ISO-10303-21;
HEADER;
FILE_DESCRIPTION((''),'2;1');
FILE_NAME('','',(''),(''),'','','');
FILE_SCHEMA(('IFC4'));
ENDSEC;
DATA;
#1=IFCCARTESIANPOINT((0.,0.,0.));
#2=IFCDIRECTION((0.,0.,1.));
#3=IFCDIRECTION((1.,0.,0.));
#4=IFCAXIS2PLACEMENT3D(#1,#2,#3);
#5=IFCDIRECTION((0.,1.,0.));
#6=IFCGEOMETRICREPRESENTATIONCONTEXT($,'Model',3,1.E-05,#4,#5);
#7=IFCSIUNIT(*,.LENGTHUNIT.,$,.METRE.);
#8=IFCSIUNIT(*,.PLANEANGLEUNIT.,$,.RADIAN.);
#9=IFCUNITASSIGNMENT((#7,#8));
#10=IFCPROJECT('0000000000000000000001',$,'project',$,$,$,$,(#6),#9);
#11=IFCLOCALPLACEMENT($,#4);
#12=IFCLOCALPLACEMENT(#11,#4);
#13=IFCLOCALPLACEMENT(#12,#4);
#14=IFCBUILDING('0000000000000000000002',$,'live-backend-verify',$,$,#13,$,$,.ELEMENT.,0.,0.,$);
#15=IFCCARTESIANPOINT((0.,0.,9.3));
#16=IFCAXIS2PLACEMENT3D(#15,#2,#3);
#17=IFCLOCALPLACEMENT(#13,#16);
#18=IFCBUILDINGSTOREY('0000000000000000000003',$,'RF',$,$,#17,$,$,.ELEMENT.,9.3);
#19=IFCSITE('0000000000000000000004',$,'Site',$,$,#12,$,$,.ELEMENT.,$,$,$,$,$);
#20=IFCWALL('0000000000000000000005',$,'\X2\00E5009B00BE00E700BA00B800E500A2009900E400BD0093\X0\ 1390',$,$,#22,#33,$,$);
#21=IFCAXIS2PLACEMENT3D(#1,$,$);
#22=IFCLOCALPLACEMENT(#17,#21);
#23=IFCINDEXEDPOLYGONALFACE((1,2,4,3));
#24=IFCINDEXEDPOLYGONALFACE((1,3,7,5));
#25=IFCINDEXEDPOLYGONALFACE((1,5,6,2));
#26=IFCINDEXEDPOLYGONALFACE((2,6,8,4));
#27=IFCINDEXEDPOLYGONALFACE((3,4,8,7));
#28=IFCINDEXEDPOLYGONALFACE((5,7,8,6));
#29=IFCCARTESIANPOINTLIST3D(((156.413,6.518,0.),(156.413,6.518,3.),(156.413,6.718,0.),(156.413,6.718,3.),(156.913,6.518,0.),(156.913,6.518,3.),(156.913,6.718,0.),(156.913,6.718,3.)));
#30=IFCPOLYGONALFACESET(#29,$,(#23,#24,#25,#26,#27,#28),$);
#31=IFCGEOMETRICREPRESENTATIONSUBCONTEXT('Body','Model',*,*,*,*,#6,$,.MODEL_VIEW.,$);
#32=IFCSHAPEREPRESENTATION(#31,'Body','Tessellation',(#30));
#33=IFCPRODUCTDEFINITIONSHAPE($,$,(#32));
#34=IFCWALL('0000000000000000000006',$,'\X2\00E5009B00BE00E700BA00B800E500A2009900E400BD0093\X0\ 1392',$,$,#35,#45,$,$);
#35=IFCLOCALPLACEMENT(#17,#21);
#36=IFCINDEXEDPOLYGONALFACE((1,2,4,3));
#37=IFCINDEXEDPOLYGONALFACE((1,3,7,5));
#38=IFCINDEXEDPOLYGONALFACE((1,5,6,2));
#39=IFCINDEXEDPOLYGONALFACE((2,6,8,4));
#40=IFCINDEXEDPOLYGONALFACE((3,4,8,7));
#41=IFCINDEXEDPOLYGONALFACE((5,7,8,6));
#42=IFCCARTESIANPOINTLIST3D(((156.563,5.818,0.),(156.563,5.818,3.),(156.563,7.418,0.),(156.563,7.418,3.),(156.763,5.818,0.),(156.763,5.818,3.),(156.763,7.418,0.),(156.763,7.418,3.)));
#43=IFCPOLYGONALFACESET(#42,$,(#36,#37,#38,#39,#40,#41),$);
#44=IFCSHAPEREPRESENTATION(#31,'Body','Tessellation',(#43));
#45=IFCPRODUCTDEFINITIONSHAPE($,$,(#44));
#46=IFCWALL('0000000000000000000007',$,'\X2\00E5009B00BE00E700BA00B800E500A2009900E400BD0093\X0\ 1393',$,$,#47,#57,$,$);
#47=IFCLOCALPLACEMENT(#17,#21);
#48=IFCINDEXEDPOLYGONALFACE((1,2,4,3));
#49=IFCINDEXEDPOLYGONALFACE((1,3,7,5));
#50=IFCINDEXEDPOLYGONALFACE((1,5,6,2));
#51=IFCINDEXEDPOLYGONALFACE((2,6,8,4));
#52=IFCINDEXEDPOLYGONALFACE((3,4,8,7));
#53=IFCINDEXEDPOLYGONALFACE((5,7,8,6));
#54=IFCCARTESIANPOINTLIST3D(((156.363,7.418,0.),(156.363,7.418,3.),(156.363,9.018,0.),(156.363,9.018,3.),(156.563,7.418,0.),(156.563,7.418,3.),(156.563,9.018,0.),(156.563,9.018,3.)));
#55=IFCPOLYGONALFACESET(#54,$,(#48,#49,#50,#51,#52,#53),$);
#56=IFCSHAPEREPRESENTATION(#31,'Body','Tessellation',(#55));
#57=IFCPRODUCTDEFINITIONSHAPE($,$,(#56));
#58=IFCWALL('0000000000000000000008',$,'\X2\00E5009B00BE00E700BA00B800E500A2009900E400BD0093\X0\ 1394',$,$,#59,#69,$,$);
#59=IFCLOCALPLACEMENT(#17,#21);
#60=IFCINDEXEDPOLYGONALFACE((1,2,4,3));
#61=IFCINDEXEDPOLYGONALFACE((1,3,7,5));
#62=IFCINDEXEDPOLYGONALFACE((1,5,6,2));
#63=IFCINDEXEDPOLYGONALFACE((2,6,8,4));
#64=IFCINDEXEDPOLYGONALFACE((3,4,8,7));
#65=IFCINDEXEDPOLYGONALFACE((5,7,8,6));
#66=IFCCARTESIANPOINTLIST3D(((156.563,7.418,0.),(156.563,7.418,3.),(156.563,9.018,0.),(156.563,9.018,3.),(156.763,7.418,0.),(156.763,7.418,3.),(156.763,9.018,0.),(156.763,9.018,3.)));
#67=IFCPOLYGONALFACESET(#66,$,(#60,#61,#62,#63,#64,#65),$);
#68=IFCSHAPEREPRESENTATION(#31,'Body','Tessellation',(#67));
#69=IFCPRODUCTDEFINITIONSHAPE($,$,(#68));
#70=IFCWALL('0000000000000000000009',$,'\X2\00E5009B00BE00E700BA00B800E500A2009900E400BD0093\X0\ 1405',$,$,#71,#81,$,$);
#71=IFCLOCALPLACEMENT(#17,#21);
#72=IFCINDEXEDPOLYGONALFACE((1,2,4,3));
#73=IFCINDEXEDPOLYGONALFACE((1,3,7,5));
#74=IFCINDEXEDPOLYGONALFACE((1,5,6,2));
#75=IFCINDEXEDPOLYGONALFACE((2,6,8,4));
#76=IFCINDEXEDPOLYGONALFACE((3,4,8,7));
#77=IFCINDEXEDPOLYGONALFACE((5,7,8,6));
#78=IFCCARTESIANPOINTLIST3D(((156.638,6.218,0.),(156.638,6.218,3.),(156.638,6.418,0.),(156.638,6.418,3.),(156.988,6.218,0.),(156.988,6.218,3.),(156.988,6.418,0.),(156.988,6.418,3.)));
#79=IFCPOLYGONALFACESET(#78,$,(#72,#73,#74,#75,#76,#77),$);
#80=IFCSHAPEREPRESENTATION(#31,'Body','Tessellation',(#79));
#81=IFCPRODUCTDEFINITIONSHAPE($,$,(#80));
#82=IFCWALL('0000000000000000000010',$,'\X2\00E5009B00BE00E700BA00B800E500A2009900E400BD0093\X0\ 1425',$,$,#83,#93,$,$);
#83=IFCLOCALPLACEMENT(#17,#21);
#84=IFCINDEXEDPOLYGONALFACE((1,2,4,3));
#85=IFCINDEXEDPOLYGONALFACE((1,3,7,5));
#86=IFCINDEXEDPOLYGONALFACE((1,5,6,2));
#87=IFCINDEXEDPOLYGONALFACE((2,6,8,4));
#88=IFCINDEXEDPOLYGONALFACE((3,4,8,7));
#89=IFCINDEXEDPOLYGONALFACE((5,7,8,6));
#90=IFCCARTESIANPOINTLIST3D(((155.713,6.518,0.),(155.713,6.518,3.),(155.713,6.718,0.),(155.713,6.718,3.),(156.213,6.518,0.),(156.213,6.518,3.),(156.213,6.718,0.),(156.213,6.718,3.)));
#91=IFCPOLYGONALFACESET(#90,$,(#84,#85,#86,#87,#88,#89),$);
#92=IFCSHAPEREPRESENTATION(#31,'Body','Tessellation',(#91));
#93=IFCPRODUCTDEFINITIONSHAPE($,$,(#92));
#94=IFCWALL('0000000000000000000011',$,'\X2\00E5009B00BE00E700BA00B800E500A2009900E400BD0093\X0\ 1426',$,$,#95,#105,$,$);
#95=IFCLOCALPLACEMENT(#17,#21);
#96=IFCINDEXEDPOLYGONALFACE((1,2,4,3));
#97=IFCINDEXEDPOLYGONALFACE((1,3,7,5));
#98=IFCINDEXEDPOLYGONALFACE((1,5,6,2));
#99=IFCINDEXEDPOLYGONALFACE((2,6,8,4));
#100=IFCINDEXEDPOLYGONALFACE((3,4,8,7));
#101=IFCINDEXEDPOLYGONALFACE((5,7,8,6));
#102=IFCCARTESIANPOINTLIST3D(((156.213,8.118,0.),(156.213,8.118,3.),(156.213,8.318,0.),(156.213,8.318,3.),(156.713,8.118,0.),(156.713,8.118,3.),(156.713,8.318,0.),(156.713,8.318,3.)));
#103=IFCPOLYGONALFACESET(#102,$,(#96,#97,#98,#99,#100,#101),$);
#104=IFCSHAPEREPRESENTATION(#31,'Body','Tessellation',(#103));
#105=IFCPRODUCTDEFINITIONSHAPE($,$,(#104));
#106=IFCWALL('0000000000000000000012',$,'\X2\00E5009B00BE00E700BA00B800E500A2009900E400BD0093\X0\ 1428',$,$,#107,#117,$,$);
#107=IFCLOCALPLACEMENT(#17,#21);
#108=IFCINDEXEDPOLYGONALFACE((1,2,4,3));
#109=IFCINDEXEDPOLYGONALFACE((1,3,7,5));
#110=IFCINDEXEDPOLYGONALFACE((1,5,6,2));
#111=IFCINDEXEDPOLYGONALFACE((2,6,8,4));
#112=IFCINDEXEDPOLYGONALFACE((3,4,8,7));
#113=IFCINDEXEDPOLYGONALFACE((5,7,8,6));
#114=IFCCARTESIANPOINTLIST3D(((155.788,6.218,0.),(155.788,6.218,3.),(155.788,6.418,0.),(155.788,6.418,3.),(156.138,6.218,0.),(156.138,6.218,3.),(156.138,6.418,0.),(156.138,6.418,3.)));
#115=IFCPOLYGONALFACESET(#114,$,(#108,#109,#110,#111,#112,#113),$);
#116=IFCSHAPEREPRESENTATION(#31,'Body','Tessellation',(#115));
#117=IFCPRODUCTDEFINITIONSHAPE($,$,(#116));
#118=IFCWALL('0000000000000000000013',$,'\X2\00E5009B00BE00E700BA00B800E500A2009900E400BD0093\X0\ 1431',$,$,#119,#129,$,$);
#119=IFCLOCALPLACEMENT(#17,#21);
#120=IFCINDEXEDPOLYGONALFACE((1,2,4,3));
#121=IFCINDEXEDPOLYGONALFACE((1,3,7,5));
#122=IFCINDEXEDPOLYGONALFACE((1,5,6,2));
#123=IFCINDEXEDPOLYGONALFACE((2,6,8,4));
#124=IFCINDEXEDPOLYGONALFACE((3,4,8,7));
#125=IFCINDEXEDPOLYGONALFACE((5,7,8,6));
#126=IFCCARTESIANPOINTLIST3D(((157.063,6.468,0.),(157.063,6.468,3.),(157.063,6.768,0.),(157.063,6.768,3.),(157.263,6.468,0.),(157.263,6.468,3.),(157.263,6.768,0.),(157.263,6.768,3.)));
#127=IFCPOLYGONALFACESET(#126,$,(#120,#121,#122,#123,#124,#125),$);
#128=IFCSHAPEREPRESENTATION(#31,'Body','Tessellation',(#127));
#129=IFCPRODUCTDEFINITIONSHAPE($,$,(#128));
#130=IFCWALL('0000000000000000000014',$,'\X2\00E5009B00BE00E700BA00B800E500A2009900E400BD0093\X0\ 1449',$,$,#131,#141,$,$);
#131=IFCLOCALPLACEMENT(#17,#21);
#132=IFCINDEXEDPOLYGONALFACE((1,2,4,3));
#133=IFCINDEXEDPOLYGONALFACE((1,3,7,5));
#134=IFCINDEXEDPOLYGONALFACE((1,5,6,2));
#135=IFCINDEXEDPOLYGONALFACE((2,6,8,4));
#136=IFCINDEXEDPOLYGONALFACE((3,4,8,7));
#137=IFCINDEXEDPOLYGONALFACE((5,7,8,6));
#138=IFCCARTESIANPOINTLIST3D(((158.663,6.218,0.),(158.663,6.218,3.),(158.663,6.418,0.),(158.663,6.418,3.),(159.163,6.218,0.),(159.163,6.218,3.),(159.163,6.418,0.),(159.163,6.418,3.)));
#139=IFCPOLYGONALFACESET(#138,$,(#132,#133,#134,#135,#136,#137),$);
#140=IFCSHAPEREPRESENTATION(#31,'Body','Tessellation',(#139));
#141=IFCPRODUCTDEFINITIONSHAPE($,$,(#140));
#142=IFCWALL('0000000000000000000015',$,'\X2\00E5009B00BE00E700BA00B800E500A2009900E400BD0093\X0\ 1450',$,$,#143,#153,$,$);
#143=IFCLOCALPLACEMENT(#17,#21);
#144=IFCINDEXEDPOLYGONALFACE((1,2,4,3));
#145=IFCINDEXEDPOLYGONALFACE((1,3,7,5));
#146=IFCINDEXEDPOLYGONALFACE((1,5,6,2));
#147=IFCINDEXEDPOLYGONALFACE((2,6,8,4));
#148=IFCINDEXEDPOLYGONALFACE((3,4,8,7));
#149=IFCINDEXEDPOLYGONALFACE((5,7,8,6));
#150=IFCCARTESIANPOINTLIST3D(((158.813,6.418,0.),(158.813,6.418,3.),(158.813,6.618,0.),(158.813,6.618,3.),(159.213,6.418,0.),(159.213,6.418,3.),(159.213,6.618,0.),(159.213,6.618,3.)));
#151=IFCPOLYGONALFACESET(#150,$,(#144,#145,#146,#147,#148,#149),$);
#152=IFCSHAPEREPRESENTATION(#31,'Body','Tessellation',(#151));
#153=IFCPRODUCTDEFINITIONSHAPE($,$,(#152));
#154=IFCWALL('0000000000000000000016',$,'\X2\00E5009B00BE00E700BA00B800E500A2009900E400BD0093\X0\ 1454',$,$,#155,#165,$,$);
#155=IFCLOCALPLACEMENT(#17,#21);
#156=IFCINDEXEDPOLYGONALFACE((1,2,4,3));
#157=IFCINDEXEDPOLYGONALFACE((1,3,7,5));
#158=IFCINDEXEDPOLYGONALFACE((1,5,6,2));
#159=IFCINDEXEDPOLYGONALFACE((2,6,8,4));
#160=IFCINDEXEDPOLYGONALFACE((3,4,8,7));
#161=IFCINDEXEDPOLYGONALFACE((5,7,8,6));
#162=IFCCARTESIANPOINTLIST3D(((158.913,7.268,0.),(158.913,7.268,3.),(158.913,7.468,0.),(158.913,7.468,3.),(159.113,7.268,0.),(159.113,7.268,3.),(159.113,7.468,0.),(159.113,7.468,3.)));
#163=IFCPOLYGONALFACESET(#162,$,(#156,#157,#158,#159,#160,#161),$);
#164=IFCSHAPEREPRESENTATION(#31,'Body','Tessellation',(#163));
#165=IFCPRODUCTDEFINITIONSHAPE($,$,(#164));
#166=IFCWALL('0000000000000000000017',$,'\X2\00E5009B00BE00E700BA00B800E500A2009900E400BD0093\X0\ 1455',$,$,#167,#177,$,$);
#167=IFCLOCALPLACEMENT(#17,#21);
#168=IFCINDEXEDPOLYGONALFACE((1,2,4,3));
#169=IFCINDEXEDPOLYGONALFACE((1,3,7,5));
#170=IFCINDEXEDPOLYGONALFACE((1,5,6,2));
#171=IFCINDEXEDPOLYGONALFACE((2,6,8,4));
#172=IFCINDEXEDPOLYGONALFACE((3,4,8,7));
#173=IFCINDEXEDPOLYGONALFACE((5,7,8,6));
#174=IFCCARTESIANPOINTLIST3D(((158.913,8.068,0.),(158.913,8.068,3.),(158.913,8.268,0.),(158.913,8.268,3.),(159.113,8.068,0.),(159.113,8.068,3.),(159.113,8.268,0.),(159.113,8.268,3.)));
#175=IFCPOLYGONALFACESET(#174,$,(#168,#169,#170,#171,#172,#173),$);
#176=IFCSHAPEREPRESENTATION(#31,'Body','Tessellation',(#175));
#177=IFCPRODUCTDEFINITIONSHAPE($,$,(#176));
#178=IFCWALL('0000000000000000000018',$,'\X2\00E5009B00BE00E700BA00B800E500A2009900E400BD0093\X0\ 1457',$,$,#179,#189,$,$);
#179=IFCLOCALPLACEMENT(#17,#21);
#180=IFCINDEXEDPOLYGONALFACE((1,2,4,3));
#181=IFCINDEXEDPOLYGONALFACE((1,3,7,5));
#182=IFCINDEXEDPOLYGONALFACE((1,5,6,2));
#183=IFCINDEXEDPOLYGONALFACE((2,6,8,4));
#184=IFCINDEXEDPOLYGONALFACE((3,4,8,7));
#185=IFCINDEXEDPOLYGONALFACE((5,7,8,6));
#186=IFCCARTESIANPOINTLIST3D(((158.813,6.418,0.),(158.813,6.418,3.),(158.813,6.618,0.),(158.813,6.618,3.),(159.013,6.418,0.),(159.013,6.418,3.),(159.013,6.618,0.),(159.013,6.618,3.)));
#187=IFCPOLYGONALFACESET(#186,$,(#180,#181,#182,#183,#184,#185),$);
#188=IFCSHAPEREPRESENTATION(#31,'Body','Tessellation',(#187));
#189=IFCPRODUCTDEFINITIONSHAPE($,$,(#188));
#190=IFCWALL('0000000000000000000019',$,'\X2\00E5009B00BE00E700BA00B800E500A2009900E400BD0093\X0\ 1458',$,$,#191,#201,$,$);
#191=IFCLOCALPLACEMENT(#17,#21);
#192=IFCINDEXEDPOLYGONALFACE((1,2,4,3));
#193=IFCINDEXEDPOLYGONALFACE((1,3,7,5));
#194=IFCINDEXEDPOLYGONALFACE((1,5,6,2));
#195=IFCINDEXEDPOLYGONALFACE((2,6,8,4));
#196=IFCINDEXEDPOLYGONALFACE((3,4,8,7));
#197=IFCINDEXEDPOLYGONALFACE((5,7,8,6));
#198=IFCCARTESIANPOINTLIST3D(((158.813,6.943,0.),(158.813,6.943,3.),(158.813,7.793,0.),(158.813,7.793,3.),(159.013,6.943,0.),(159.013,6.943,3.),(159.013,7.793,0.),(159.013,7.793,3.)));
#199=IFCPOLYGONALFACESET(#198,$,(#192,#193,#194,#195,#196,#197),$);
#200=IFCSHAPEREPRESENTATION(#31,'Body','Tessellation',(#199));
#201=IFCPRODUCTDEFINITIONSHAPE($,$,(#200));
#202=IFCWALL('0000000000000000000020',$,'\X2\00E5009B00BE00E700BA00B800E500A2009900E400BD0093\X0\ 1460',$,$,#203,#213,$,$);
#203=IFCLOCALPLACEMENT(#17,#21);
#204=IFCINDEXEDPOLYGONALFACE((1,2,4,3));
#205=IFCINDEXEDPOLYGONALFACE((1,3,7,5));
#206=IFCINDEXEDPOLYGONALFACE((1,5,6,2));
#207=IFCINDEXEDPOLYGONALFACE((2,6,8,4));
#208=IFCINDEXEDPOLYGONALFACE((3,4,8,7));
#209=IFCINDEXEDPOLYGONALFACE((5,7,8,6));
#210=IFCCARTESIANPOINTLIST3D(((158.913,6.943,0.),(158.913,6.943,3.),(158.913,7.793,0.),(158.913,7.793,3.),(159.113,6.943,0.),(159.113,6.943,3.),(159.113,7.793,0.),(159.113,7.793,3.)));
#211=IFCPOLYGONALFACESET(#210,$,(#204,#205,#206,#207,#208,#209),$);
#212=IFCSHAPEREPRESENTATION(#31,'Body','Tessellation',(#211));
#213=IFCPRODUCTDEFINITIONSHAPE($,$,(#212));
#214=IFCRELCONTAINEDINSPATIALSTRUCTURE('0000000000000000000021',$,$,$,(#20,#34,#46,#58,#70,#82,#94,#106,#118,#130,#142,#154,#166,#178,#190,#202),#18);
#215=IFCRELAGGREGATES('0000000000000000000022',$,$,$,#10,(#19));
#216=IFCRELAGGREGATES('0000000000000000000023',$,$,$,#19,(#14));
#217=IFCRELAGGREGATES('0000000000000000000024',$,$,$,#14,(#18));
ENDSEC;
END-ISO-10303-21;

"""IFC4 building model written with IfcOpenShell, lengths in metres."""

from ifc_helpers import new_model, si_unit, direction, frame, frame_2d, origin_with_axes, place, context, subcontext, project, spatial, rectangle, extrude, element, save


model = new_model("IFC4")

# Units and contexts
model_context = context("Model", 3, precision=1e-05, world=origin_with_axes(), true_north=direction((0.0, 1.0, 0.0)))
body_context = subcontext(model_context, "Body", "Model", "MODEL_VIEW")
ifc_project = project(units=[si_unit("LENGTHUNIT", "METRE"), si_unit("PLANEANGLEUNIT", "RADIAN")], contexts=[model_context])

# Site, building, storey
placement = place(None, origin_with_axes())
site_placement = place(placement, origin_with_axes())
site = spatial("IfcSite", under=ifc_project, at=site_placement, Name="Site", CompositionType="ELEMENT")
building_placement = place(site_placement, origin_with_axes())
building = spatial("IfcBuilding", under=site, at=building_placement, Name="live-backend-verify", CompositionType="ELEMENT", ElevationOfRefHeight=0.0, ElevationOfTerrain=0.0)
storey_placement = place(building_placement, frame((0.0, 0.0, 9.3), z_axis=(0.0, 0.0, 1.0), x_axis=(1.0, 0.0, 0.0)))
storey = spatial("IfcBuildingStorey", under=building, at=storey_placement, Name="RF", CompositionType="ELEMENT", Elevation=9.3)

# Walls
wall_1_placement = place(storey_placement, frame((156.663, 6.618, 0.0), z_axis=(0.0, 0.0, 1.0), x_axis=(1.0, 0.0, 0.0)))
element("IfcWall", 1, at=wall_1_placement, inside=storey, Name="å\u009b¾çº¸å¢\u0099ä½\u0093 1390", context=body_context, shape_type="SweptSolid", body=[
    extrude(rectangle(XDim=0.5, YDim=0.2, at=frame_2d((0.0, 0.0), x_axis=(1.0, 0.0, 0.0))), frame((0.0, 0.0, 0.0), z_axis=(0.0, 0.0, 1.0)), (0.0, 0.0, 1.0), 3.0),
])
for number, where, z_axis, x_axis, name in (
    (2, (156.663, 6.618, 0.0), (0.0, 0.0, 1.0), (0.0, 1.0, 0.0), "å\u009b¾çº¸å¢\u0099ä½\u0093 1392"),
    (3, (156.463, 8.218, 0.0), (0.0, 0.0, 1.0), (0.0, -1.0, 0.0), "å\u009b¾çº¸å¢\u0099ä½\u0093 1393"),
    (4, (156.663, 8.218, 0.0), (0.0, 0.0, 1.0), (0.0, -1.0, 0.0), "å\u009b¾çº¸å¢\u0099ä½\u0093 1394"),
):
    element("IfcWall", number, at=place(storey_placement, frame(where, z_axis=z_axis, x_axis=x_axis)), inside=storey, Name=name, context=body_context, shape_type="SweptSolid", body=[
        extrude(rectangle(XDim=1.6, YDim=0.2, at=frame_2d((0.0, 0.0), x_axis=(1.0, 0.0, 0.0))), frame((0.0, 0.0, 0.0), z_axis=(0.0, 0.0, 1.0)), (0.0, 0.0, 1.0), 3.0),
    ])
wall_2_placement = place(storey_placement, frame((156.813, 6.318, 0.0), z_axis=(0.0, 0.0, 1.0), x_axis=(1.0, 0.0, 0.0)))
element("IfcWall", 5, at=wall_2_placement, inside=storey, Name="å\u009b¾çº¸å¢\u0099ä½\u0093 1405", context=body_context, shape_type="SweptSolid", body=[
    extrude(rectangle(XDim=0.35, YDim=0.2, at=frame_2d((0.0, 0.0), x_axis=(1.0, 0.0, 0.0))), frame((0.0, 0.0, 0.0), z_axis=(0.0, 0.0, 1.0)), (0.0, 0.0, 1.0), 3.0),
])
for number, where, z_axis, x_axis, name in (
    (6, (155.963, 6.618, 0.0), (0.0, 0.0, 1.0), (1.0, 0.0, 0.0), "å\u009b¾çº¸å¢\u0099ä½\u0093 1425"),
    (7, (156.463, 8.218, 0.0), (0.0, 0.0, 1.0), (-1.0, 0.0, 0.0), "å\u009b¾çº¸å¢\u0099ä½\u0093 1426"),
):
    element("IfcWall", number, at=place(storey_placement, frame(where, z_axis=z_axis, x_axis=x_axis)), inside=storey, Name=name, context=body_context, shape_type="SweptSolid", body=[
        extrude(rectangle(XDim=0.5, YDim=0.2, at=frame_2d((0.0, 0.0), x_axis=(1.0, 0.0, 0.0))), frame((0.0, 0.0, 0.0), z_axis=(0.0, 0.0, 1.0)), (0.0, 0.0, 1.0), 3.0),
    ])
for number, where, z_axis, x_axis, name in (
    (8, (155.963, 6.318, 0.0), (0.0, 0.0, 1.0), (1.0, 0.0, 0.0), "å\u009b¾çº¸å¢\u0099ä½\u0093 1428"),
):
    element("IfcWall", number, at=place(storey_placement, frame(where, z_axis=z_axis, x_axis=x_axis)), inside=storey, Name=name, context=body_context, shape_type="SweptSolid", body=[
        extrude(rectangle(XDim=0.35, YDim=0.2, at=frame_2d((0.0, 0.0), x_axis=(1.0, 0.0, 0.0))), frame((0.0, 0.0, 0.0), z_axis=(0.0, 0.0, 1.0)), (0.0, 0.0, 1.0), 3.0),
    ])
wall_3_placement = place(storey_placement, frame((157.163, 6.618, 0.0), z_axis=(0.0, 0.0, 1.0), x_axis=(0.0, -1.0, 0.0)))
element("IfcWall", 9, at=wall_3_placement, inside=storey, Name="å\u009b¾çº¸å¢\u0099ä½\u0093 1431", context=body_context, shape_type="SweptSolid", body=[
    extrude(rectangle(XDim=0.3, YDim=0.2, at=frame_2d((0.0, 0.0), x_axis=(1.0, 0.0, 0.0))), frame((0.0, 0.0, 0.0), z_axis=(0.0, 0.0, 1.0)), (0.0, 0.0, 1.0), 3.0),
])
for number, where, z_axis, x_axis, name in (
    (10, (158.913, 6.318, 0.0), (0.0, 0.0, 1.0), (1.0, 0.0, 0.0), "å\u009b¾çº¸å¢\u0099ä½\u0093 1449"),
):
    element("IfcWall", number, at=place(storey_placement, frame(where, z_axis=z_axis, x_axis=x_axis)), inside=storey, Name=name, context=body_context, shape_type="SweptSolid", body=[
        extrude(rectangle(XDim=0.5, YDim=0.2, at=frame_2d((0.0, 0.0), x_axis=(1.0, 0.0, 0.0))), frame((0.0, 0.0, 0.0), z_axis=(0.0, 0.0, 1.0)), (0.0, 0.0, 1.0), 3.0),
    ])
wall_4_placement = place(storey_placement, frame((159.013, 6.518, 0.0), z_axis=(0.0, 0.0, 1.0), x_axis=(1.0, 0.0, 0.0)))
element("IfcWall", 11, at=wall_4_placement, inside=storey, Name="å\u009b¾çº¸å¢\u0099ä½\u0093 1450", context=body_context, shape_type="SweptSolid", body=[
    extrude(rectangle(XDim=0.4, YDim=0.2, at=frame_2d((0.0, 0.0), x_axis=(1.0, 0.0, 0.0))), frame((0.0, 0.0, 0.0), z_axis=(0.0, 0.0, 1.0)), (0.0, 0.0, 1.0), 3.0),
])
for number, where, z_axis, x_axis, name in (
    (12, (159.013, 7.368, 0.0), (0.0, 0.0, 1.0), (-1.0, 0.0, 0.0), "å\u009b¾çº¸å¢\u0099ä½\u0093 1454"),
    (13, (159.013, 8.168, 0.0), (0.0, 0.0, 1.0), (-1.0, 0.0, 0.0), "å\u009b¾çº¸å¢\u0099ä½\u0093 1455"),
    (14, (158.913, 6.518, 0.0), (0.0, 0.0, 1.0), (0.0, -1.0, 0.0), "å\u009b¾çº¸å¢\u0099ä½\u0093 1457"),
):
    element("IfcWall", number, at=place(storey_placement, frame(where, z_axis=z_axis, x_axis=x_axis)), inside=storey, Name=name, context=body_context, shape_type="SweptSolid", body=[
        extrude(rectangle(XDim=0.2, YDim=0.2, at=frame_2d((0.0, 0.0), x_axis=(1.0, 0.0, 0.0))), frame((0.0, 0.0, 0.0), z_axis=(0.0, 0.0, 1.0)), (0.0, 0.0, 1.0), 3.0),
    ])
for number, where, z_axis, x_axis, name in (
    (15, (158.913, 7.368, 0.0), (0.0, 0.0, 1.0), (0.0, -1.0, 0.0), "å\u009b¾çº¸å¢\u0099ä½\u0093 1458"),
    (16, (159.013, 7.368, 0.0), (0.0, 0.0, 1.0), (0.0, -1.0, 0.0), "å\u009b¾çº¸å¢\u0099ä½\u0093 1460"),
):
    element("IfcWall", number, at=place(storey_placement, frame(where, z_axis=z_axis, x_axis=x_axis)), inside=storey, Name=name, context=body_context, shape_type="SweptSolid", body=[
        extrude(rectangle(XDim=0.85, YDim=0.2, at=frame_2d((0.0, 0.0), x_axis=(1.0, 0.0, 0.0))), frame((0.0, 0.0, 0.0), z_axis=(0.0, 0.0, 1.0)), (0.0, 0.0, 1.0), 3.0),
    ])

save(model, "model.ifc")
